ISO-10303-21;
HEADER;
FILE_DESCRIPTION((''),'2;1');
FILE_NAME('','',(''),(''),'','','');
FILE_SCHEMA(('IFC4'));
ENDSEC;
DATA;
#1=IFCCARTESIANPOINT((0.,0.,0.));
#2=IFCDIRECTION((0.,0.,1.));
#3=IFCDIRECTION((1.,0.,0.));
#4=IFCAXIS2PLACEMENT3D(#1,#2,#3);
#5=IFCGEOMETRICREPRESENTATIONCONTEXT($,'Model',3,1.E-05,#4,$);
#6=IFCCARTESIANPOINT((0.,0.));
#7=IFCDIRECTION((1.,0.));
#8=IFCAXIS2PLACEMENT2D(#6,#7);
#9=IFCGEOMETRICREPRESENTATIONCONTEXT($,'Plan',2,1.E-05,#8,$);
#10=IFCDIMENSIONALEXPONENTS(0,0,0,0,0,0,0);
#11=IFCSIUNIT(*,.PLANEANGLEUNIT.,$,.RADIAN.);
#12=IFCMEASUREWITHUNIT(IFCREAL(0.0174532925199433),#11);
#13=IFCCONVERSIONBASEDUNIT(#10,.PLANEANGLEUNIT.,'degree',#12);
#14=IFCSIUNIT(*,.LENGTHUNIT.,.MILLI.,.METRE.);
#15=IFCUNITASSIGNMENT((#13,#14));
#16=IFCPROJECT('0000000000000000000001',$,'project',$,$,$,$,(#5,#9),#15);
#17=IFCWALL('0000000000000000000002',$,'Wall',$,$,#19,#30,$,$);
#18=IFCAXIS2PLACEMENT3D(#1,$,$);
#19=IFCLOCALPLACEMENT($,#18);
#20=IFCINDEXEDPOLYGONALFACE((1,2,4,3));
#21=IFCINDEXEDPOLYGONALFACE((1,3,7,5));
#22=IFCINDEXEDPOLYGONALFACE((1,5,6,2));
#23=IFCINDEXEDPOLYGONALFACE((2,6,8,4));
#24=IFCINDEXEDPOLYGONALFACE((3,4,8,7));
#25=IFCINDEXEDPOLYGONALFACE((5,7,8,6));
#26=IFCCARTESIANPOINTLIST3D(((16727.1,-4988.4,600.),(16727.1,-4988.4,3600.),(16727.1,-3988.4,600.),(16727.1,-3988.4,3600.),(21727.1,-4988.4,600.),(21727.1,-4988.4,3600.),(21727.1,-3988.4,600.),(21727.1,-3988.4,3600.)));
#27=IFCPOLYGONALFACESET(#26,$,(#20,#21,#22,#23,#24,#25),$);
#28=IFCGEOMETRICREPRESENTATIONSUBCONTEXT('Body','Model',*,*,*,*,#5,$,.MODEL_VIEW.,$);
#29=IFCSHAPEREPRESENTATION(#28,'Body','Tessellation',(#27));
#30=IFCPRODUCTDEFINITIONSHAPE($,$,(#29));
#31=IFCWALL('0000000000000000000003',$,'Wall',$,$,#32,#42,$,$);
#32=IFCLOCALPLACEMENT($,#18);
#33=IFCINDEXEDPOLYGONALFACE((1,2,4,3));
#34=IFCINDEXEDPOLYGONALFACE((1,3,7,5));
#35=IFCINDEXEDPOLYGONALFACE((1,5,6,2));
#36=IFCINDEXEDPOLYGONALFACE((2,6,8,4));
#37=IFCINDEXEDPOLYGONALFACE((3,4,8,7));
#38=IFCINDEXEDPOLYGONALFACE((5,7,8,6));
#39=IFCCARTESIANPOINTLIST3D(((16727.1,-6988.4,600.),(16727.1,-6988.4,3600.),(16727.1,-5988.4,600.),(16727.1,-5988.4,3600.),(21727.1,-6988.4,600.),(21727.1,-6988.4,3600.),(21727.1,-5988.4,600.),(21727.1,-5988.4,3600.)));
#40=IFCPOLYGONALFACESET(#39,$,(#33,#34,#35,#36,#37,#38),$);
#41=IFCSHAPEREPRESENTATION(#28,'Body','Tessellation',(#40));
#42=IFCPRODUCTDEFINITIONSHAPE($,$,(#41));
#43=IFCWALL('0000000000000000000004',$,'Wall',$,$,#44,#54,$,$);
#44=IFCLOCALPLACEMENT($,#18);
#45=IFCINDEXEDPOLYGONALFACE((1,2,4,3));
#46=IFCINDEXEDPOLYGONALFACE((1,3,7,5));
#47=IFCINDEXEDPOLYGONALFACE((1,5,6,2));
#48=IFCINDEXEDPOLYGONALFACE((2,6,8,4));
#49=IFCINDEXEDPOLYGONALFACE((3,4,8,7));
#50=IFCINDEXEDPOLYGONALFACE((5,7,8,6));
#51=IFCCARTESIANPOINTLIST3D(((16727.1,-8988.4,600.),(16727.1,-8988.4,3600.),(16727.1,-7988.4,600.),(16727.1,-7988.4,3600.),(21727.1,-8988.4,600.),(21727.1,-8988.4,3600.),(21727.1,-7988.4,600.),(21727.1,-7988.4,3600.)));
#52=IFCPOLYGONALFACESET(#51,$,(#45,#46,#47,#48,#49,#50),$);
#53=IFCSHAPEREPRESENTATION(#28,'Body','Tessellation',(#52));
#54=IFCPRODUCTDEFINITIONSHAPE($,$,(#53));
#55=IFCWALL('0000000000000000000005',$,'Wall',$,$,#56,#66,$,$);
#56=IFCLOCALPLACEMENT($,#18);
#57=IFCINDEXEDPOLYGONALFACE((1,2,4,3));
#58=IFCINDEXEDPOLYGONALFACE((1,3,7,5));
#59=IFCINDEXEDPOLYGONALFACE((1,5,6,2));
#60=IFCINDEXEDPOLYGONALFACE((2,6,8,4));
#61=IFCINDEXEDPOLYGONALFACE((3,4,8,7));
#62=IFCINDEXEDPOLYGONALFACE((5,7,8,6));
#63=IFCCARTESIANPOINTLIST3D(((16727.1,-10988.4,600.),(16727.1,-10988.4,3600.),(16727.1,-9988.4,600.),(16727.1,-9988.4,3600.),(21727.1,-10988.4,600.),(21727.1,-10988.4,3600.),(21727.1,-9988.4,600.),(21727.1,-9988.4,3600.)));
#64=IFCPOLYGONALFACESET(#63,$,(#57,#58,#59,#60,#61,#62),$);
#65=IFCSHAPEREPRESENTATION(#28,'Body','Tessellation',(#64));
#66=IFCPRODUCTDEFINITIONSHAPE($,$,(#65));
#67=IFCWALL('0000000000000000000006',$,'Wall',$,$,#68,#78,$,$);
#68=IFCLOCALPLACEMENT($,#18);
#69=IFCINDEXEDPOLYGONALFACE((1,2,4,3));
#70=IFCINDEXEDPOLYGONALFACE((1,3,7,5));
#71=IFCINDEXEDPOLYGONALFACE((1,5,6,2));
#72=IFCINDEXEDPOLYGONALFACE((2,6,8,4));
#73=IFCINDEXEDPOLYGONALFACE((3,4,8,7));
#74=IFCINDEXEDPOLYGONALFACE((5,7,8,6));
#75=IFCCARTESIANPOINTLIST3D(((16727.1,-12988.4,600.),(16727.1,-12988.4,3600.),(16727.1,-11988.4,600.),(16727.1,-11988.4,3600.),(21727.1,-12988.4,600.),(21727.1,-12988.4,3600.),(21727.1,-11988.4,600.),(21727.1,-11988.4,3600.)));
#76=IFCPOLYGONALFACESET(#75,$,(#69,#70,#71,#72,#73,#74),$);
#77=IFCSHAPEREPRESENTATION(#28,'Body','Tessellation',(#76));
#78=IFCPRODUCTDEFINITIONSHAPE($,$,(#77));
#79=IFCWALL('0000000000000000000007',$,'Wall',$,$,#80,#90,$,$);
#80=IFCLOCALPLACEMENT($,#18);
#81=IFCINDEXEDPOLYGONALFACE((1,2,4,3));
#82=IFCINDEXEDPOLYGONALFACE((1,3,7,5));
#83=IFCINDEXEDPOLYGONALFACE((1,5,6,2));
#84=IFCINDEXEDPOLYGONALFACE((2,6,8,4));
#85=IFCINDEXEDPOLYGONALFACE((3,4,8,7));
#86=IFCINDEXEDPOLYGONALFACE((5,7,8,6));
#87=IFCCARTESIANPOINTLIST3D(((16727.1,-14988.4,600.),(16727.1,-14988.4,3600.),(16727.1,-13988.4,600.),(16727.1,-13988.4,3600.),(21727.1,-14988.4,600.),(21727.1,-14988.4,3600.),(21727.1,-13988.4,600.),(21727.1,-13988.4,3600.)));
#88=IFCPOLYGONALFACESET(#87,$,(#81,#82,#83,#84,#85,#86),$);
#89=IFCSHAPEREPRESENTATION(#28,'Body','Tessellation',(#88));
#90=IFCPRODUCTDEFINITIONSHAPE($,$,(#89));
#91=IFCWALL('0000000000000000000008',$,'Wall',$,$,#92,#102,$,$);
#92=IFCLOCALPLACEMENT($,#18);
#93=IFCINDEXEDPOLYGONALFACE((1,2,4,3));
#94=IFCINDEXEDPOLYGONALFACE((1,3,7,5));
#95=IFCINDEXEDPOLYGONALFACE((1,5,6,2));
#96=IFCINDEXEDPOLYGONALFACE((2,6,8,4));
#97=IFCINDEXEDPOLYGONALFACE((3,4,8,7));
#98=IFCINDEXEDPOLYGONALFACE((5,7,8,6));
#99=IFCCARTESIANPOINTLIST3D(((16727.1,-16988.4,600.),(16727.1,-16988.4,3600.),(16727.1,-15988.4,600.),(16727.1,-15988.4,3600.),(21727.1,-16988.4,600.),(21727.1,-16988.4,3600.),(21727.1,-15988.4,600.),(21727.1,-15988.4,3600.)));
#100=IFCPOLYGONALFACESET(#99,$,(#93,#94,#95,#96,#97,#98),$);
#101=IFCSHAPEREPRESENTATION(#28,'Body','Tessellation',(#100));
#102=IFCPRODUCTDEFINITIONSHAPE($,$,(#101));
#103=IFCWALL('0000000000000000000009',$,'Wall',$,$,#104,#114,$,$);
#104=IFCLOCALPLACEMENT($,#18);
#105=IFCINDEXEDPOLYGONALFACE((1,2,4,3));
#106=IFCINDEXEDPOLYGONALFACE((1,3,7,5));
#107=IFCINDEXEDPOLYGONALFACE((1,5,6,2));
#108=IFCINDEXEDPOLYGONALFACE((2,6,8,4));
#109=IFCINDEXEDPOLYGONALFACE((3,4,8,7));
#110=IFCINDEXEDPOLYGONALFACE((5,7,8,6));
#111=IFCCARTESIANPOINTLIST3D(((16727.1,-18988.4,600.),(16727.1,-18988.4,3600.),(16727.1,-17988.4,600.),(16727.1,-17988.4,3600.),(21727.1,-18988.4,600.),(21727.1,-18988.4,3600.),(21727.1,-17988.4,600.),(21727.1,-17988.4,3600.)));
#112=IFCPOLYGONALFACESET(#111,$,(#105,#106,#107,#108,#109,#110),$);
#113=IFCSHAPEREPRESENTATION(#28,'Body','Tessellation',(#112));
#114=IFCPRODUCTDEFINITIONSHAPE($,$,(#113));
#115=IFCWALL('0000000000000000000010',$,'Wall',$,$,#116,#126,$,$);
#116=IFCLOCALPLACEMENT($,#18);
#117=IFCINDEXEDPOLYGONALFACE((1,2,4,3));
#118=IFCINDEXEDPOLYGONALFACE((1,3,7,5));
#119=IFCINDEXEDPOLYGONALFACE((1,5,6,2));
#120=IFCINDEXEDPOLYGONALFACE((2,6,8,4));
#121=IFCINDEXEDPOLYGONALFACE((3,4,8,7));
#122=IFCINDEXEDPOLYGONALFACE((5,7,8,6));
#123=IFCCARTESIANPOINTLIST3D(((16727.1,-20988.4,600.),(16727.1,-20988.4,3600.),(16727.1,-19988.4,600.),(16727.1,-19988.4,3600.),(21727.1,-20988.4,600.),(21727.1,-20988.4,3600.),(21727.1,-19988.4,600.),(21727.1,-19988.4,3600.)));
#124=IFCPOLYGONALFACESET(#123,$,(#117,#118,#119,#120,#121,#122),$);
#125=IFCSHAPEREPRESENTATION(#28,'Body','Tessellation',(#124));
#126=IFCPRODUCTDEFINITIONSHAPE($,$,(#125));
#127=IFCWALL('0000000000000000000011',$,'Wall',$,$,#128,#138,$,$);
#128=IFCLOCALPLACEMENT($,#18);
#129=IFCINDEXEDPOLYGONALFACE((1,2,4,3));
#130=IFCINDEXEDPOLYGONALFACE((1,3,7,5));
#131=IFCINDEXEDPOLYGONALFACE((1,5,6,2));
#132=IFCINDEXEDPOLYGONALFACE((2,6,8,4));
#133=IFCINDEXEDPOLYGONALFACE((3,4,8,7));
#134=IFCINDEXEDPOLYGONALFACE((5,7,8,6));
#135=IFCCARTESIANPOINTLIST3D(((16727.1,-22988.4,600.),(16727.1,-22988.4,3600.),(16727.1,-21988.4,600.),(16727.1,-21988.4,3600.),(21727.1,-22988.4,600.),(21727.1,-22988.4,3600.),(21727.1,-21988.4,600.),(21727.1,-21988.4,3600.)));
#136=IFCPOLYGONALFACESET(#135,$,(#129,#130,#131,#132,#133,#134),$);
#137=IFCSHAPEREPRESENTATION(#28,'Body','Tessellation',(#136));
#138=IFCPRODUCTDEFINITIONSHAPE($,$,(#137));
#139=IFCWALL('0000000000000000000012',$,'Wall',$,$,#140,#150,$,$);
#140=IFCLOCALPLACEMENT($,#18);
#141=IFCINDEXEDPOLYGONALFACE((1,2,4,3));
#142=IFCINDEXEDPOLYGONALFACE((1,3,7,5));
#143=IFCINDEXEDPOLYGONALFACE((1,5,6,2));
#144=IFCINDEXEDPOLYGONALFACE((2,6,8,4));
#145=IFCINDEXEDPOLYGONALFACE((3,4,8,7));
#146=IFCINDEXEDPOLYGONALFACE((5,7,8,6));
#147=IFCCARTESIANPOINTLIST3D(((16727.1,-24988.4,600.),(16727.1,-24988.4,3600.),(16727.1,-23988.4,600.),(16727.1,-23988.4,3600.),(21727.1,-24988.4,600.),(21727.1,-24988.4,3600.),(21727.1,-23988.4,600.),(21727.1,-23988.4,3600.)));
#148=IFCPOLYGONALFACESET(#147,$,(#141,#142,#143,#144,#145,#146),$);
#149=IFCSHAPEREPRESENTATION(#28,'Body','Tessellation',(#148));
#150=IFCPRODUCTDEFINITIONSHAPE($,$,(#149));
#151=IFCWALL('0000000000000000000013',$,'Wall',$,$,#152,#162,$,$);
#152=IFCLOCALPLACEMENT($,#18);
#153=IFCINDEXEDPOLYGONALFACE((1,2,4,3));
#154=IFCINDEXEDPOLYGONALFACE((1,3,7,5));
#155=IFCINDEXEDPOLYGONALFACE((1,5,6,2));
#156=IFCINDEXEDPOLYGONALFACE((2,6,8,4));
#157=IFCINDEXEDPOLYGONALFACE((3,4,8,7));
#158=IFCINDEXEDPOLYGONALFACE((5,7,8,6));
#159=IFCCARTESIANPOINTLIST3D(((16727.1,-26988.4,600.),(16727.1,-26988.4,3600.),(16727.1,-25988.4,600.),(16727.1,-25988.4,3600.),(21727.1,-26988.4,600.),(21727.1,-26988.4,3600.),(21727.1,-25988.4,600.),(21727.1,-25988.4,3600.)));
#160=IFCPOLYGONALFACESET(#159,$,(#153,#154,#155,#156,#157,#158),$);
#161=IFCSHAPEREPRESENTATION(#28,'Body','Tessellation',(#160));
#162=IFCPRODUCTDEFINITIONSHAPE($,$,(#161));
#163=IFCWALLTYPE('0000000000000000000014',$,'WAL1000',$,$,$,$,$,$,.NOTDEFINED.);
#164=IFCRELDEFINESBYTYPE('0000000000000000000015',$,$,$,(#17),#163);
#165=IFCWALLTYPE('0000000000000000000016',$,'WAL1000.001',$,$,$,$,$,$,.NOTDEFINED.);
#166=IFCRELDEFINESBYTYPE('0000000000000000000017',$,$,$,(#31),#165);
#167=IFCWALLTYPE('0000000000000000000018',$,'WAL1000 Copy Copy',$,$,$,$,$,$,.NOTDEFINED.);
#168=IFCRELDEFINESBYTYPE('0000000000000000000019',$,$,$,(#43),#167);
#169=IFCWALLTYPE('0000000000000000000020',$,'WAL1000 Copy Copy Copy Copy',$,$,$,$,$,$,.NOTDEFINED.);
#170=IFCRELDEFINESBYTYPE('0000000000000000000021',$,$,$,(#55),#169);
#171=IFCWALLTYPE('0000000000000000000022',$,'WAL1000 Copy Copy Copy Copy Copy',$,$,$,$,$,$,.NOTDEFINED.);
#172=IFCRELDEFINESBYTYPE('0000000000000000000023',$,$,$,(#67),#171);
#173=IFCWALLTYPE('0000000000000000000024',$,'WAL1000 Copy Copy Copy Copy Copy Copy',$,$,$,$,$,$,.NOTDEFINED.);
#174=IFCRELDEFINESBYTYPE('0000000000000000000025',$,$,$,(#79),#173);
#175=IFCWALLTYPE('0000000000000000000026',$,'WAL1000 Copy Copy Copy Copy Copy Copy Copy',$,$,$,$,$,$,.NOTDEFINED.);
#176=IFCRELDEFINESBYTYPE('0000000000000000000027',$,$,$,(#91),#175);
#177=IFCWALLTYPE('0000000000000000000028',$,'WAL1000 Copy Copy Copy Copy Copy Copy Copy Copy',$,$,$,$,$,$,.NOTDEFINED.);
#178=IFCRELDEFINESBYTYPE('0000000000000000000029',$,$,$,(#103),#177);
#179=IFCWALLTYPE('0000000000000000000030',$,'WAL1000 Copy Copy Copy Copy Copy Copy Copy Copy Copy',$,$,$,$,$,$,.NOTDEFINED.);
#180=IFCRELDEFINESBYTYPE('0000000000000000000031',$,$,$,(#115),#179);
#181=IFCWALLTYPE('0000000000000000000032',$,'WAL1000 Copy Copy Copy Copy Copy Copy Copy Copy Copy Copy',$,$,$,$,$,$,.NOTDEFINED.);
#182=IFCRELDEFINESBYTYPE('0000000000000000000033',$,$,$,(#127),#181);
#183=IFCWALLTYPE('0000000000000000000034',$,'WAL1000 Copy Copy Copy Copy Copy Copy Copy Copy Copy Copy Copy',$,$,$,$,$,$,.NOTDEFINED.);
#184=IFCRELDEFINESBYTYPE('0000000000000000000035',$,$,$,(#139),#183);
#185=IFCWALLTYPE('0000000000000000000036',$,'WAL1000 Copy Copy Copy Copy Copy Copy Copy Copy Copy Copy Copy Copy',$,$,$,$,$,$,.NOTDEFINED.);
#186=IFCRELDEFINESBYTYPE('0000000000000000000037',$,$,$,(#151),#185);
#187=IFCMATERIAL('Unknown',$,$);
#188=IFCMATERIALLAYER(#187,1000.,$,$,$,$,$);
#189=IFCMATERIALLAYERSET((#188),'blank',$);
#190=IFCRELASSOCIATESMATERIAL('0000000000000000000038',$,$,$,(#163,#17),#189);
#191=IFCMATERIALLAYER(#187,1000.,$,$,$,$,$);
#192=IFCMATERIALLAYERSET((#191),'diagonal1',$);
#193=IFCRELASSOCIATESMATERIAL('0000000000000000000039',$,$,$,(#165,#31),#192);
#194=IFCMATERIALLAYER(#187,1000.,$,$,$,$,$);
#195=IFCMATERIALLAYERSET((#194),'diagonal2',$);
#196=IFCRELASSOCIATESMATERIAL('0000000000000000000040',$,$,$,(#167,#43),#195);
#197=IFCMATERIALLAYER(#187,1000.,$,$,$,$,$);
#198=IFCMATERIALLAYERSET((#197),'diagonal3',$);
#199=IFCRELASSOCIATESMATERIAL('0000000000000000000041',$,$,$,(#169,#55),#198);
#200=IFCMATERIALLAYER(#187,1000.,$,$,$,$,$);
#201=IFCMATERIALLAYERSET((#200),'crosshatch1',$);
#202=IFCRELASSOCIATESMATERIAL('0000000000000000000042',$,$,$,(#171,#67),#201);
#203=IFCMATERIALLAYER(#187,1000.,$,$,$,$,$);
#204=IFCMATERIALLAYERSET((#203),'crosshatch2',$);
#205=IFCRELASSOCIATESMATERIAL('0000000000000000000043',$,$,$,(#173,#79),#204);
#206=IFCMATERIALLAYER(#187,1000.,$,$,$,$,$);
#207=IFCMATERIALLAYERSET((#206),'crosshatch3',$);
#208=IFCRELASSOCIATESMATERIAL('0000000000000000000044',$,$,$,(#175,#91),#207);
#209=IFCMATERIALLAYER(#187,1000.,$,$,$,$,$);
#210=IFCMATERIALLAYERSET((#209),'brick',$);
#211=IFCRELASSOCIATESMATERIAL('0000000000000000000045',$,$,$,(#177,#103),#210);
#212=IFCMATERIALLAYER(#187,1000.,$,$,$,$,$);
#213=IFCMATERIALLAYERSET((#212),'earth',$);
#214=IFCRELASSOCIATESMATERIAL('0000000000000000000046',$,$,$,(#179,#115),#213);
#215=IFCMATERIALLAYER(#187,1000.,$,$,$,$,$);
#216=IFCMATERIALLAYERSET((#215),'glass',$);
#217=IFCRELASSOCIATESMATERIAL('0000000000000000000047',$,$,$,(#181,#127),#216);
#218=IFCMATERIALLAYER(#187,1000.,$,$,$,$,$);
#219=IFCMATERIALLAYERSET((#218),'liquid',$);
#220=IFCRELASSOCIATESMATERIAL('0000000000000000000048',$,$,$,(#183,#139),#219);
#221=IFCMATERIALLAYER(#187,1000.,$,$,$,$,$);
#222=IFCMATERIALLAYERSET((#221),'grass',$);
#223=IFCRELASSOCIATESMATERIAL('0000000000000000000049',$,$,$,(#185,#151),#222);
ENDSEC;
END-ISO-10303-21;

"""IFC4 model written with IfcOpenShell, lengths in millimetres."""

from ifc_helpers import new_model, entity, si_unit, converted_unit, frame, origin_with_axes, origin_2d_with_axis, place, context, subcontext, project, indexed_curve, outline, extrude, material, layer, layer_set, layer_usage, type_object, element, save


model = new_model("IFC4")

# Units and contexts
model_context = context("Model", 3, precision=1e-05, world=origin_with_axes())
plan_context = context("Plan", 2, precision=1e-05, world=origin_2d_with_axis())
body_context = subcontext(model_context, "Body", "Model", "MODEL_VIEW")
ifc_project = project(units=[converted_unit("PLANEANGLEUNIT", "degree", entity("IfcReal", 0.0174532925199433), si_unit("PLANEANGLEUNIT", "RADIAN"), dimensions=[0, 0, 0, 0, 0, 0, 0]), si_unit("LENGTHUNIT", "METRE", prefix="MILLI")], contexts=[model_context, plan_context])

# Walls
ifc_material = material(Name="Unknown")
ifc_layer_1 = layer(ifc_material, 1000.0)
ifc_layer_set_1 = layer_set([ifc_layer_1], Name="blank")
ifc_layer_usage_1 = layer_usage(ifc_layer_set_1, "AXIS2", "POSITIVE", 0.0)
wall_type_1 = type_object("IfcWallType", Name="WAL1000", PredefinedType="NOTDEFINED", material=ifc_layer_set_1)
wall_1_placement = place(None, frame((16727.1, -4988.4, 600.0), z_axis=(0.0, 0.0, 1.0), x_axis=(1.0, 0.0, 0.0)))
element("IfcWall", 1, at=wall_1_placement, type_object=wall_type_1, material=ifc_layer_usage_1, Name="Wall", context=body_context, shape_type="SweptSolid", body=[
    extrude(outline(indexed_curve([(0.0, 0.0), (0.0, 1000.0), (5000.0, 1000.0), (5000.0, 0.0), (0.0, 0.0)], self_intersect=False)), origin_with_axes(), (0.0, 0.0, 1.0), 3000.0),
])
ifc_layer_2 = layer(ifc_material, 1000.0)
ifc_layer_set_2 = layer_set([ifc_layer_2], Name="diagonal1")
ifc_layer_usage_2 = layer_usage(ifc_layer_set_2, "AXIS2", "POSITIVE", 0.0)
wall_type_2 = type_object("IfcWallType", Name="WAL1000.001", PredefinedType="NOTDEFINED", material=ifc_layer_set_2)
wall_2_placement = place(None, frame((16727.1, -6988.4, 600.0), z_axis=(0.0, 0.0, 1.0), x_axis=(1.0, 0.0, 0.0)))
element("IfcWall", 2, at=wall_2_placement, type_object=wall_type_2, material=ifc_layer_usage_2, Name="Wall", context=body_context, shape_type="SweptSolid", body=[
    extrude(outline(indexed_curve([(0.0, 0.0), (0.0, 1000.0), (5000.0, 1000.0), (5000.0, 0.0), (0.0, 0.0)], self_intersect=False)), origin_with_axes(), (0.0, 0.0, 1.0), 3000.0),
])
ifc_layer_3 = layer(ifc_material, 1000.0)
ifc_layer_set_3 = layer_set([ifc_layer_3], Name="diagonal2")
ifc_layer_usage_3 = layer_usage(ifc_layer_set_3, "AXIS2", "POSITIVE", 0.0)
wall_type_3 = type_object("IfcWallType", Name="WAL1000 Copy Copy", PredefinedType="NOTDEFINED", material=ifc_layer_set_3)
wall_3_placement = place(None, frame((16727.1, -8988.4, 600.0), z_axis=(0.0, 0.0, 1.0), x_axis=(1.0, 0.0, 0.0)))
element("IfcWall", 3, at=wall_3_placement, type_object=wall_type_3, material=ifc_layer_usage_3, Name="Wall", context=body_context, shape_type="SweptSolid", body=[
    extrude(outline(indexed_curve([(0.0, 0.0), (0.0, 1000.0), (5000.0, 1000.0), (5000.0, 0.0), (0.0, 0.0)], self_intersect=False)), origin_with_axes(), (0.0, 0.0, 1.0), 3000.0),
])
ifc_layer_4 = layer(ifc_material, 1000.0)
ifc_layer_set_4 = layer_set([ifc_layer_4], Name="diagonal3")
ifc_layer_usage_4 = layer_usage(ifc_layer_set_4, "AXIS2", "POSITIVE", 0.0)
wall_type_4 = type_object("IfcWallType", Name="WAL1000 Copy Copy Copy Copy", PredefinedType="NOTDEFINED", material=ifc_layer_set_4)
wall_4_placement = place(None, frame((16727.1, -10988.4, 600.0), z_axis=(0.0, 0.0, 1.0), x_axis=(1.0, 0.0, 0.0)))
element("IfcWall", 4, at=wall_4_placement, type_object=wall_type_4, material=ifc_layer_usage_4, Name="Wall", context=body_context, shape_type="SweptSolid", body=[
    extrude(outline(indexed_curve([(0.0, 0.0), (0.0, 1000.0), (5000.0, 1000.0), (5000.0, 0.0), (0.0, 0.0)], self_intersect=False)), origin_with_axes(), (0.0, 0.0, 1.0), 3000.0),
])
ifc_layer_5 = layer(ifc_material, 1000.0)
ifc_layer_set_5 = layer_set([ifc_layer_5], Name="crosshatch1")
ifc_layer_usage_5 = layer_usage(ifc_layer_set_5, "AXIS2", "POSITIVE", 0.0)
wall_type_5 = type_object("IfcWallType", Name="WAL1000 Copy Copy Copy Copy Copy", PredefinedType="NOTDEFINED", material=ifc_layer_set_5)
wall_5_placement = place(None, frame((16727.1, -12988.4, 600.0), z_axis=(0.0, 0.0, 1.0), x_axis=(1.0, 0.0, 0.0)))
element("IfcWall", 5, at=wall_5_placement, type_object=wall_type_5, material=ifc_layer_usage_5, Name="Wall", context=body_context, shape_type="SweptSolid", body=[
    extrude(outline(indexed_curve([(0.0, 0.0), (0.0, 1000.0), (5000.0, 1000.0), (5000.0, 0.0), (0.0, 0.0)], self_intersect=False)), origin_with_axes(), (0.0, 0.0, 1.0), 3000.0),
])
ifc_layer_6 = layer(ifc_material, 1000.0)
ifc_layer_set_6 = layer_set([ifc_layer_6], Name="crosshatch2")
ifc_layer_usage_6 = layer_usage(ifc_layer_set_6, "AXIS2", "POSITIVE", 0.0)
wall_type_6 = type_object("IfcWallType", Name="WAL1000 Copy Copy Copy Copy Copy Copy", PredefinedType="NOTDEFINED", material=ifc_layer_set_6)
wall_6_placement = place(None, frame((16727.1, -14988.4, 600.0), z_axis=(0.0, 0.0, 1.0), x_axis=(1.0, 0.0, 0.0)))
element("IfcWall", 6, at=wall_6_placement, type_object=wall_type_6, material=ifc_layer_usage_6, Name="Wall", context=body_context, shape_type="SweptSolid", body=[
    extrude(outline(indexed_curve([(0.0, 0.0), (0.0, 1000.0), (5000.0, 1000.0), (5000.0, 0.0), (0.0, 0.0)], self_intersect=False)), origin_with_axes(), (0.0, 0.0, 1.0), 3000.0),
])
ifc_layer_7 = layer(ifc_material, 1000.0)
ifc_layer_set_7 = layer_set([ifc_layer_7], Name="crosshatch3")
ifc_layer_usage_7 = layer_usage(ifc_layer_set_7, "AXIS2", "POSITIVE", 0.0)
wall_type_7 = type_object("IfcWallType", Name="WAL1000 Copy Copy Copy Copy Copy Copy Copy", PredefinedType="NOTDEFINED", material=ifc_layer_set_7)
wall_7_placement = place(None, frame((16727.1, -16988.4, 600.0), z_axis=(0.0, 0.0, 1.0), x_axis=(1.0, 0.0, 0.0)))
element("IfcWall", 7, at=wall_7_placement, type_object=wall_type_7, material=ifc_layer_usage_7, Name="Wall", context=body_context, shape_type="SweptSolid", body=[
    extrude(outline(indexed_curve([(0.0, 0.0), (0.0, 1000.0), (5000.0, 1000.0), (5000.0, 0.0), (0.0, 0.0)], self_intersect=False)), origin_with_axes(), (0.0, 0.0, 1.0), 3000.0),
])
ifc_layer_8 = layer(ifc_material, 1000.0)
ifc_layer_set_8 = layer_set([ifc_layer_8], Name="brick")
ifc_layer_usage_8 = layer_usage(ifc_layer_set_8, "AXIS2", "POSITIVE", 0.0)
wall_type_8 = type_object("IfcWallType", Name="WAL1000 Copy Copy Copy Copy Copy Copy Copy Copy", PredefinedType="NOTDEFINED", material=ifc_layer_set_8)
wall_8_placement = place(None, frame((16727.1, -18988.4, 600.0), z_axis=(0.0, 0.0, 1.0), x_axis=(1.0, 0.0, 0.0)))
element("IfcWall", 8, at=wall_8_placement, type_object=wall_type_8, material=ifc_layer_usage_8, Name="Wall", context=body_context, shape_type="SweptSolid", body=[
    extrude(outline(indexed_curve([(0.0, 0.0), (0.0, 1000.0), (5000.0, 1000.0), (5000.0, 0.0), (0.0, 0.0)], self_intersect=False)), origin_with_axes(), (0.0, 0.0, 1.0), 3000.0),
])
ifc_layer_9 = layer(ifc_material, 1000.0)
ifc_layer_set_9 = layer_set([ifc_layer_9], Name="earth")
ifc_layer_usage_9 = layer_usage(ifc_layer_set_9, "AXIS2", "POSITIVE", 0.0)
wall_type_9 = type_object("IfcWallType", Name="WAL1000 Copy Copy Copy Copy Copy Copy Copy Copy Copy", PredefinedType="NOTDEFINED", material=ifc_layer_set_9)
wall_9_placement = place(None, frame((16727.1, -20988.4, 600.0), z_axis=(0.0, 0.0, 1.0), x_axis=(1.0, 0.0, 0.0)))
element("IfcWall", 9, at=wall_9_placement, type_object=wall_type_9, material=ifc_layer_usage_9, Name="Wall", context=body_context, shape_type="SweptSolid", body=[
    extrude(outline(indexed_curve([(0.0, 0.0), (0.0, 1000.0), (5000.0, 1000.0), (5000.0, 0.0), (0.0, 0.0)], self_intersect=False)), origin_with_axes(), (0.0, 0.0, 1.0), 3000.0),
])
ifc_layer_10 = layer(ifc_material, 1000.0)
ifc_layer_set_10 = layer_set([ifc_layer_10], Name="glass")
ifc_layer_usage_10 = layer_usage(ifc_layer_set_10, "AXIS2", "POSITIVE", 0.0)
wall_type_10 = type_object("IfcWallType", Name="WAL1000 Copy Copy Copy Copy Copy Copy Copy Copy Copy Copy", PredefinedType="NOTDEFINED", material=ifc_layer_set_10)
wall_10_placement = place(None, frame((16727.1, -22988.4, 600.0), z_axis=(0.0, 0.0, 1.0), x_axis=(1.0, 0.0, 0.0)))
element("IfcWall", 10, at=wall_10_placement, type_object=wall_type_10, material=ifc_layer_usage_10, Name="Wall", context=body_context, shape_type="SweptSolid", body=[
    extrude(outline(indexed_curve([(0.0, 0.0), (0.0, 1000.0), (5000.0, 1000.0), (5000.0, 0.0), (0.0, 0.0)], self_intersect=False)), origin_with_axes(), (0.0, 0.0, 1.0), 3000.0),
])
ifc_layer_11 = layer(ifc_material, 1000.0)
ifc_layer_set_11 = layer_set([ifc_layer_11], Name="liquid")
ifc_layer_usage_11 = layer_usage(ifc_layer_set_11, "AXIS2", "POSITIVE", 0.0)
wall_type_11 = type_object("IfcWallType", Name="WAL1000 Copy Copy Copy Copy Copy Copy Copy Copy Copy Copy Copy", PredefinedType="NOTDEFINED", material=ifc_layer_set_11)
wall_11_placement = place(None, frame((16727.1, -24988.4, 600.0), z_axis=(0.0, 0.0, 1.0), x_axis=(1.0, 0.0, 0.0)))
element("IfcWall", 11, at=wall_11_placement, type_object=wall_type_11, material=ifc_layer_usage_11, Name="Wall", context=body_context, shape_type="SweptSolid", body=[
    extrude(outline(indexed_curve([(0.0, 0.0), (0.0, 1000.0), (5000.0, 1000.0), (5000.0, 0.0), (0.0, 0.0)], self_intersect=False)), origin_with_axes(), (0.0, 0.0, 1.0), 3000.0),
])
ifc_layer_12 = layer(ifc_material, 1000.0)
ifc_layer_set_12 = layer_set([ifc_layer_12], Name="grass")
ifc_layer_usage_12 = layer_usage(ifc_layer_set_12, "AXIS2", "POSITIVE", 0.0)
wall_type_12 = type_object("IfcWallType", Name="WAL1000 Copy Copy Copy Copy Copy Copy Copy Copy Copy Copy Copy Copy", PredefinedType="NOTDEFINED", material=ifc_layer_set_12)
wall_12_placement = place(None, frame((16727.1, -26988.4, 600.0), z_axis=(0.0, 0.0, 1.0), x_axis=(1.0, 0.0, 0.0)))
element("IfcWall", 12, at=wall_12_placement, type_object=wall_type_12, material=ifc_layer_usage_12, Name="Wall", context=body_context, shape_type="SweptSolid", body=[
    extrude(outline(indexed_curve([(0.0, 0.0), (0.0, 1000.0), (5000.0, 1000.0), (5000.0, 0.0), (0.0, 0.0)], self_intersect=False)), origin_with_axes(), (0.0, 0.0, 1.0), 3000.0),
])

save(model, "model.ifc")
